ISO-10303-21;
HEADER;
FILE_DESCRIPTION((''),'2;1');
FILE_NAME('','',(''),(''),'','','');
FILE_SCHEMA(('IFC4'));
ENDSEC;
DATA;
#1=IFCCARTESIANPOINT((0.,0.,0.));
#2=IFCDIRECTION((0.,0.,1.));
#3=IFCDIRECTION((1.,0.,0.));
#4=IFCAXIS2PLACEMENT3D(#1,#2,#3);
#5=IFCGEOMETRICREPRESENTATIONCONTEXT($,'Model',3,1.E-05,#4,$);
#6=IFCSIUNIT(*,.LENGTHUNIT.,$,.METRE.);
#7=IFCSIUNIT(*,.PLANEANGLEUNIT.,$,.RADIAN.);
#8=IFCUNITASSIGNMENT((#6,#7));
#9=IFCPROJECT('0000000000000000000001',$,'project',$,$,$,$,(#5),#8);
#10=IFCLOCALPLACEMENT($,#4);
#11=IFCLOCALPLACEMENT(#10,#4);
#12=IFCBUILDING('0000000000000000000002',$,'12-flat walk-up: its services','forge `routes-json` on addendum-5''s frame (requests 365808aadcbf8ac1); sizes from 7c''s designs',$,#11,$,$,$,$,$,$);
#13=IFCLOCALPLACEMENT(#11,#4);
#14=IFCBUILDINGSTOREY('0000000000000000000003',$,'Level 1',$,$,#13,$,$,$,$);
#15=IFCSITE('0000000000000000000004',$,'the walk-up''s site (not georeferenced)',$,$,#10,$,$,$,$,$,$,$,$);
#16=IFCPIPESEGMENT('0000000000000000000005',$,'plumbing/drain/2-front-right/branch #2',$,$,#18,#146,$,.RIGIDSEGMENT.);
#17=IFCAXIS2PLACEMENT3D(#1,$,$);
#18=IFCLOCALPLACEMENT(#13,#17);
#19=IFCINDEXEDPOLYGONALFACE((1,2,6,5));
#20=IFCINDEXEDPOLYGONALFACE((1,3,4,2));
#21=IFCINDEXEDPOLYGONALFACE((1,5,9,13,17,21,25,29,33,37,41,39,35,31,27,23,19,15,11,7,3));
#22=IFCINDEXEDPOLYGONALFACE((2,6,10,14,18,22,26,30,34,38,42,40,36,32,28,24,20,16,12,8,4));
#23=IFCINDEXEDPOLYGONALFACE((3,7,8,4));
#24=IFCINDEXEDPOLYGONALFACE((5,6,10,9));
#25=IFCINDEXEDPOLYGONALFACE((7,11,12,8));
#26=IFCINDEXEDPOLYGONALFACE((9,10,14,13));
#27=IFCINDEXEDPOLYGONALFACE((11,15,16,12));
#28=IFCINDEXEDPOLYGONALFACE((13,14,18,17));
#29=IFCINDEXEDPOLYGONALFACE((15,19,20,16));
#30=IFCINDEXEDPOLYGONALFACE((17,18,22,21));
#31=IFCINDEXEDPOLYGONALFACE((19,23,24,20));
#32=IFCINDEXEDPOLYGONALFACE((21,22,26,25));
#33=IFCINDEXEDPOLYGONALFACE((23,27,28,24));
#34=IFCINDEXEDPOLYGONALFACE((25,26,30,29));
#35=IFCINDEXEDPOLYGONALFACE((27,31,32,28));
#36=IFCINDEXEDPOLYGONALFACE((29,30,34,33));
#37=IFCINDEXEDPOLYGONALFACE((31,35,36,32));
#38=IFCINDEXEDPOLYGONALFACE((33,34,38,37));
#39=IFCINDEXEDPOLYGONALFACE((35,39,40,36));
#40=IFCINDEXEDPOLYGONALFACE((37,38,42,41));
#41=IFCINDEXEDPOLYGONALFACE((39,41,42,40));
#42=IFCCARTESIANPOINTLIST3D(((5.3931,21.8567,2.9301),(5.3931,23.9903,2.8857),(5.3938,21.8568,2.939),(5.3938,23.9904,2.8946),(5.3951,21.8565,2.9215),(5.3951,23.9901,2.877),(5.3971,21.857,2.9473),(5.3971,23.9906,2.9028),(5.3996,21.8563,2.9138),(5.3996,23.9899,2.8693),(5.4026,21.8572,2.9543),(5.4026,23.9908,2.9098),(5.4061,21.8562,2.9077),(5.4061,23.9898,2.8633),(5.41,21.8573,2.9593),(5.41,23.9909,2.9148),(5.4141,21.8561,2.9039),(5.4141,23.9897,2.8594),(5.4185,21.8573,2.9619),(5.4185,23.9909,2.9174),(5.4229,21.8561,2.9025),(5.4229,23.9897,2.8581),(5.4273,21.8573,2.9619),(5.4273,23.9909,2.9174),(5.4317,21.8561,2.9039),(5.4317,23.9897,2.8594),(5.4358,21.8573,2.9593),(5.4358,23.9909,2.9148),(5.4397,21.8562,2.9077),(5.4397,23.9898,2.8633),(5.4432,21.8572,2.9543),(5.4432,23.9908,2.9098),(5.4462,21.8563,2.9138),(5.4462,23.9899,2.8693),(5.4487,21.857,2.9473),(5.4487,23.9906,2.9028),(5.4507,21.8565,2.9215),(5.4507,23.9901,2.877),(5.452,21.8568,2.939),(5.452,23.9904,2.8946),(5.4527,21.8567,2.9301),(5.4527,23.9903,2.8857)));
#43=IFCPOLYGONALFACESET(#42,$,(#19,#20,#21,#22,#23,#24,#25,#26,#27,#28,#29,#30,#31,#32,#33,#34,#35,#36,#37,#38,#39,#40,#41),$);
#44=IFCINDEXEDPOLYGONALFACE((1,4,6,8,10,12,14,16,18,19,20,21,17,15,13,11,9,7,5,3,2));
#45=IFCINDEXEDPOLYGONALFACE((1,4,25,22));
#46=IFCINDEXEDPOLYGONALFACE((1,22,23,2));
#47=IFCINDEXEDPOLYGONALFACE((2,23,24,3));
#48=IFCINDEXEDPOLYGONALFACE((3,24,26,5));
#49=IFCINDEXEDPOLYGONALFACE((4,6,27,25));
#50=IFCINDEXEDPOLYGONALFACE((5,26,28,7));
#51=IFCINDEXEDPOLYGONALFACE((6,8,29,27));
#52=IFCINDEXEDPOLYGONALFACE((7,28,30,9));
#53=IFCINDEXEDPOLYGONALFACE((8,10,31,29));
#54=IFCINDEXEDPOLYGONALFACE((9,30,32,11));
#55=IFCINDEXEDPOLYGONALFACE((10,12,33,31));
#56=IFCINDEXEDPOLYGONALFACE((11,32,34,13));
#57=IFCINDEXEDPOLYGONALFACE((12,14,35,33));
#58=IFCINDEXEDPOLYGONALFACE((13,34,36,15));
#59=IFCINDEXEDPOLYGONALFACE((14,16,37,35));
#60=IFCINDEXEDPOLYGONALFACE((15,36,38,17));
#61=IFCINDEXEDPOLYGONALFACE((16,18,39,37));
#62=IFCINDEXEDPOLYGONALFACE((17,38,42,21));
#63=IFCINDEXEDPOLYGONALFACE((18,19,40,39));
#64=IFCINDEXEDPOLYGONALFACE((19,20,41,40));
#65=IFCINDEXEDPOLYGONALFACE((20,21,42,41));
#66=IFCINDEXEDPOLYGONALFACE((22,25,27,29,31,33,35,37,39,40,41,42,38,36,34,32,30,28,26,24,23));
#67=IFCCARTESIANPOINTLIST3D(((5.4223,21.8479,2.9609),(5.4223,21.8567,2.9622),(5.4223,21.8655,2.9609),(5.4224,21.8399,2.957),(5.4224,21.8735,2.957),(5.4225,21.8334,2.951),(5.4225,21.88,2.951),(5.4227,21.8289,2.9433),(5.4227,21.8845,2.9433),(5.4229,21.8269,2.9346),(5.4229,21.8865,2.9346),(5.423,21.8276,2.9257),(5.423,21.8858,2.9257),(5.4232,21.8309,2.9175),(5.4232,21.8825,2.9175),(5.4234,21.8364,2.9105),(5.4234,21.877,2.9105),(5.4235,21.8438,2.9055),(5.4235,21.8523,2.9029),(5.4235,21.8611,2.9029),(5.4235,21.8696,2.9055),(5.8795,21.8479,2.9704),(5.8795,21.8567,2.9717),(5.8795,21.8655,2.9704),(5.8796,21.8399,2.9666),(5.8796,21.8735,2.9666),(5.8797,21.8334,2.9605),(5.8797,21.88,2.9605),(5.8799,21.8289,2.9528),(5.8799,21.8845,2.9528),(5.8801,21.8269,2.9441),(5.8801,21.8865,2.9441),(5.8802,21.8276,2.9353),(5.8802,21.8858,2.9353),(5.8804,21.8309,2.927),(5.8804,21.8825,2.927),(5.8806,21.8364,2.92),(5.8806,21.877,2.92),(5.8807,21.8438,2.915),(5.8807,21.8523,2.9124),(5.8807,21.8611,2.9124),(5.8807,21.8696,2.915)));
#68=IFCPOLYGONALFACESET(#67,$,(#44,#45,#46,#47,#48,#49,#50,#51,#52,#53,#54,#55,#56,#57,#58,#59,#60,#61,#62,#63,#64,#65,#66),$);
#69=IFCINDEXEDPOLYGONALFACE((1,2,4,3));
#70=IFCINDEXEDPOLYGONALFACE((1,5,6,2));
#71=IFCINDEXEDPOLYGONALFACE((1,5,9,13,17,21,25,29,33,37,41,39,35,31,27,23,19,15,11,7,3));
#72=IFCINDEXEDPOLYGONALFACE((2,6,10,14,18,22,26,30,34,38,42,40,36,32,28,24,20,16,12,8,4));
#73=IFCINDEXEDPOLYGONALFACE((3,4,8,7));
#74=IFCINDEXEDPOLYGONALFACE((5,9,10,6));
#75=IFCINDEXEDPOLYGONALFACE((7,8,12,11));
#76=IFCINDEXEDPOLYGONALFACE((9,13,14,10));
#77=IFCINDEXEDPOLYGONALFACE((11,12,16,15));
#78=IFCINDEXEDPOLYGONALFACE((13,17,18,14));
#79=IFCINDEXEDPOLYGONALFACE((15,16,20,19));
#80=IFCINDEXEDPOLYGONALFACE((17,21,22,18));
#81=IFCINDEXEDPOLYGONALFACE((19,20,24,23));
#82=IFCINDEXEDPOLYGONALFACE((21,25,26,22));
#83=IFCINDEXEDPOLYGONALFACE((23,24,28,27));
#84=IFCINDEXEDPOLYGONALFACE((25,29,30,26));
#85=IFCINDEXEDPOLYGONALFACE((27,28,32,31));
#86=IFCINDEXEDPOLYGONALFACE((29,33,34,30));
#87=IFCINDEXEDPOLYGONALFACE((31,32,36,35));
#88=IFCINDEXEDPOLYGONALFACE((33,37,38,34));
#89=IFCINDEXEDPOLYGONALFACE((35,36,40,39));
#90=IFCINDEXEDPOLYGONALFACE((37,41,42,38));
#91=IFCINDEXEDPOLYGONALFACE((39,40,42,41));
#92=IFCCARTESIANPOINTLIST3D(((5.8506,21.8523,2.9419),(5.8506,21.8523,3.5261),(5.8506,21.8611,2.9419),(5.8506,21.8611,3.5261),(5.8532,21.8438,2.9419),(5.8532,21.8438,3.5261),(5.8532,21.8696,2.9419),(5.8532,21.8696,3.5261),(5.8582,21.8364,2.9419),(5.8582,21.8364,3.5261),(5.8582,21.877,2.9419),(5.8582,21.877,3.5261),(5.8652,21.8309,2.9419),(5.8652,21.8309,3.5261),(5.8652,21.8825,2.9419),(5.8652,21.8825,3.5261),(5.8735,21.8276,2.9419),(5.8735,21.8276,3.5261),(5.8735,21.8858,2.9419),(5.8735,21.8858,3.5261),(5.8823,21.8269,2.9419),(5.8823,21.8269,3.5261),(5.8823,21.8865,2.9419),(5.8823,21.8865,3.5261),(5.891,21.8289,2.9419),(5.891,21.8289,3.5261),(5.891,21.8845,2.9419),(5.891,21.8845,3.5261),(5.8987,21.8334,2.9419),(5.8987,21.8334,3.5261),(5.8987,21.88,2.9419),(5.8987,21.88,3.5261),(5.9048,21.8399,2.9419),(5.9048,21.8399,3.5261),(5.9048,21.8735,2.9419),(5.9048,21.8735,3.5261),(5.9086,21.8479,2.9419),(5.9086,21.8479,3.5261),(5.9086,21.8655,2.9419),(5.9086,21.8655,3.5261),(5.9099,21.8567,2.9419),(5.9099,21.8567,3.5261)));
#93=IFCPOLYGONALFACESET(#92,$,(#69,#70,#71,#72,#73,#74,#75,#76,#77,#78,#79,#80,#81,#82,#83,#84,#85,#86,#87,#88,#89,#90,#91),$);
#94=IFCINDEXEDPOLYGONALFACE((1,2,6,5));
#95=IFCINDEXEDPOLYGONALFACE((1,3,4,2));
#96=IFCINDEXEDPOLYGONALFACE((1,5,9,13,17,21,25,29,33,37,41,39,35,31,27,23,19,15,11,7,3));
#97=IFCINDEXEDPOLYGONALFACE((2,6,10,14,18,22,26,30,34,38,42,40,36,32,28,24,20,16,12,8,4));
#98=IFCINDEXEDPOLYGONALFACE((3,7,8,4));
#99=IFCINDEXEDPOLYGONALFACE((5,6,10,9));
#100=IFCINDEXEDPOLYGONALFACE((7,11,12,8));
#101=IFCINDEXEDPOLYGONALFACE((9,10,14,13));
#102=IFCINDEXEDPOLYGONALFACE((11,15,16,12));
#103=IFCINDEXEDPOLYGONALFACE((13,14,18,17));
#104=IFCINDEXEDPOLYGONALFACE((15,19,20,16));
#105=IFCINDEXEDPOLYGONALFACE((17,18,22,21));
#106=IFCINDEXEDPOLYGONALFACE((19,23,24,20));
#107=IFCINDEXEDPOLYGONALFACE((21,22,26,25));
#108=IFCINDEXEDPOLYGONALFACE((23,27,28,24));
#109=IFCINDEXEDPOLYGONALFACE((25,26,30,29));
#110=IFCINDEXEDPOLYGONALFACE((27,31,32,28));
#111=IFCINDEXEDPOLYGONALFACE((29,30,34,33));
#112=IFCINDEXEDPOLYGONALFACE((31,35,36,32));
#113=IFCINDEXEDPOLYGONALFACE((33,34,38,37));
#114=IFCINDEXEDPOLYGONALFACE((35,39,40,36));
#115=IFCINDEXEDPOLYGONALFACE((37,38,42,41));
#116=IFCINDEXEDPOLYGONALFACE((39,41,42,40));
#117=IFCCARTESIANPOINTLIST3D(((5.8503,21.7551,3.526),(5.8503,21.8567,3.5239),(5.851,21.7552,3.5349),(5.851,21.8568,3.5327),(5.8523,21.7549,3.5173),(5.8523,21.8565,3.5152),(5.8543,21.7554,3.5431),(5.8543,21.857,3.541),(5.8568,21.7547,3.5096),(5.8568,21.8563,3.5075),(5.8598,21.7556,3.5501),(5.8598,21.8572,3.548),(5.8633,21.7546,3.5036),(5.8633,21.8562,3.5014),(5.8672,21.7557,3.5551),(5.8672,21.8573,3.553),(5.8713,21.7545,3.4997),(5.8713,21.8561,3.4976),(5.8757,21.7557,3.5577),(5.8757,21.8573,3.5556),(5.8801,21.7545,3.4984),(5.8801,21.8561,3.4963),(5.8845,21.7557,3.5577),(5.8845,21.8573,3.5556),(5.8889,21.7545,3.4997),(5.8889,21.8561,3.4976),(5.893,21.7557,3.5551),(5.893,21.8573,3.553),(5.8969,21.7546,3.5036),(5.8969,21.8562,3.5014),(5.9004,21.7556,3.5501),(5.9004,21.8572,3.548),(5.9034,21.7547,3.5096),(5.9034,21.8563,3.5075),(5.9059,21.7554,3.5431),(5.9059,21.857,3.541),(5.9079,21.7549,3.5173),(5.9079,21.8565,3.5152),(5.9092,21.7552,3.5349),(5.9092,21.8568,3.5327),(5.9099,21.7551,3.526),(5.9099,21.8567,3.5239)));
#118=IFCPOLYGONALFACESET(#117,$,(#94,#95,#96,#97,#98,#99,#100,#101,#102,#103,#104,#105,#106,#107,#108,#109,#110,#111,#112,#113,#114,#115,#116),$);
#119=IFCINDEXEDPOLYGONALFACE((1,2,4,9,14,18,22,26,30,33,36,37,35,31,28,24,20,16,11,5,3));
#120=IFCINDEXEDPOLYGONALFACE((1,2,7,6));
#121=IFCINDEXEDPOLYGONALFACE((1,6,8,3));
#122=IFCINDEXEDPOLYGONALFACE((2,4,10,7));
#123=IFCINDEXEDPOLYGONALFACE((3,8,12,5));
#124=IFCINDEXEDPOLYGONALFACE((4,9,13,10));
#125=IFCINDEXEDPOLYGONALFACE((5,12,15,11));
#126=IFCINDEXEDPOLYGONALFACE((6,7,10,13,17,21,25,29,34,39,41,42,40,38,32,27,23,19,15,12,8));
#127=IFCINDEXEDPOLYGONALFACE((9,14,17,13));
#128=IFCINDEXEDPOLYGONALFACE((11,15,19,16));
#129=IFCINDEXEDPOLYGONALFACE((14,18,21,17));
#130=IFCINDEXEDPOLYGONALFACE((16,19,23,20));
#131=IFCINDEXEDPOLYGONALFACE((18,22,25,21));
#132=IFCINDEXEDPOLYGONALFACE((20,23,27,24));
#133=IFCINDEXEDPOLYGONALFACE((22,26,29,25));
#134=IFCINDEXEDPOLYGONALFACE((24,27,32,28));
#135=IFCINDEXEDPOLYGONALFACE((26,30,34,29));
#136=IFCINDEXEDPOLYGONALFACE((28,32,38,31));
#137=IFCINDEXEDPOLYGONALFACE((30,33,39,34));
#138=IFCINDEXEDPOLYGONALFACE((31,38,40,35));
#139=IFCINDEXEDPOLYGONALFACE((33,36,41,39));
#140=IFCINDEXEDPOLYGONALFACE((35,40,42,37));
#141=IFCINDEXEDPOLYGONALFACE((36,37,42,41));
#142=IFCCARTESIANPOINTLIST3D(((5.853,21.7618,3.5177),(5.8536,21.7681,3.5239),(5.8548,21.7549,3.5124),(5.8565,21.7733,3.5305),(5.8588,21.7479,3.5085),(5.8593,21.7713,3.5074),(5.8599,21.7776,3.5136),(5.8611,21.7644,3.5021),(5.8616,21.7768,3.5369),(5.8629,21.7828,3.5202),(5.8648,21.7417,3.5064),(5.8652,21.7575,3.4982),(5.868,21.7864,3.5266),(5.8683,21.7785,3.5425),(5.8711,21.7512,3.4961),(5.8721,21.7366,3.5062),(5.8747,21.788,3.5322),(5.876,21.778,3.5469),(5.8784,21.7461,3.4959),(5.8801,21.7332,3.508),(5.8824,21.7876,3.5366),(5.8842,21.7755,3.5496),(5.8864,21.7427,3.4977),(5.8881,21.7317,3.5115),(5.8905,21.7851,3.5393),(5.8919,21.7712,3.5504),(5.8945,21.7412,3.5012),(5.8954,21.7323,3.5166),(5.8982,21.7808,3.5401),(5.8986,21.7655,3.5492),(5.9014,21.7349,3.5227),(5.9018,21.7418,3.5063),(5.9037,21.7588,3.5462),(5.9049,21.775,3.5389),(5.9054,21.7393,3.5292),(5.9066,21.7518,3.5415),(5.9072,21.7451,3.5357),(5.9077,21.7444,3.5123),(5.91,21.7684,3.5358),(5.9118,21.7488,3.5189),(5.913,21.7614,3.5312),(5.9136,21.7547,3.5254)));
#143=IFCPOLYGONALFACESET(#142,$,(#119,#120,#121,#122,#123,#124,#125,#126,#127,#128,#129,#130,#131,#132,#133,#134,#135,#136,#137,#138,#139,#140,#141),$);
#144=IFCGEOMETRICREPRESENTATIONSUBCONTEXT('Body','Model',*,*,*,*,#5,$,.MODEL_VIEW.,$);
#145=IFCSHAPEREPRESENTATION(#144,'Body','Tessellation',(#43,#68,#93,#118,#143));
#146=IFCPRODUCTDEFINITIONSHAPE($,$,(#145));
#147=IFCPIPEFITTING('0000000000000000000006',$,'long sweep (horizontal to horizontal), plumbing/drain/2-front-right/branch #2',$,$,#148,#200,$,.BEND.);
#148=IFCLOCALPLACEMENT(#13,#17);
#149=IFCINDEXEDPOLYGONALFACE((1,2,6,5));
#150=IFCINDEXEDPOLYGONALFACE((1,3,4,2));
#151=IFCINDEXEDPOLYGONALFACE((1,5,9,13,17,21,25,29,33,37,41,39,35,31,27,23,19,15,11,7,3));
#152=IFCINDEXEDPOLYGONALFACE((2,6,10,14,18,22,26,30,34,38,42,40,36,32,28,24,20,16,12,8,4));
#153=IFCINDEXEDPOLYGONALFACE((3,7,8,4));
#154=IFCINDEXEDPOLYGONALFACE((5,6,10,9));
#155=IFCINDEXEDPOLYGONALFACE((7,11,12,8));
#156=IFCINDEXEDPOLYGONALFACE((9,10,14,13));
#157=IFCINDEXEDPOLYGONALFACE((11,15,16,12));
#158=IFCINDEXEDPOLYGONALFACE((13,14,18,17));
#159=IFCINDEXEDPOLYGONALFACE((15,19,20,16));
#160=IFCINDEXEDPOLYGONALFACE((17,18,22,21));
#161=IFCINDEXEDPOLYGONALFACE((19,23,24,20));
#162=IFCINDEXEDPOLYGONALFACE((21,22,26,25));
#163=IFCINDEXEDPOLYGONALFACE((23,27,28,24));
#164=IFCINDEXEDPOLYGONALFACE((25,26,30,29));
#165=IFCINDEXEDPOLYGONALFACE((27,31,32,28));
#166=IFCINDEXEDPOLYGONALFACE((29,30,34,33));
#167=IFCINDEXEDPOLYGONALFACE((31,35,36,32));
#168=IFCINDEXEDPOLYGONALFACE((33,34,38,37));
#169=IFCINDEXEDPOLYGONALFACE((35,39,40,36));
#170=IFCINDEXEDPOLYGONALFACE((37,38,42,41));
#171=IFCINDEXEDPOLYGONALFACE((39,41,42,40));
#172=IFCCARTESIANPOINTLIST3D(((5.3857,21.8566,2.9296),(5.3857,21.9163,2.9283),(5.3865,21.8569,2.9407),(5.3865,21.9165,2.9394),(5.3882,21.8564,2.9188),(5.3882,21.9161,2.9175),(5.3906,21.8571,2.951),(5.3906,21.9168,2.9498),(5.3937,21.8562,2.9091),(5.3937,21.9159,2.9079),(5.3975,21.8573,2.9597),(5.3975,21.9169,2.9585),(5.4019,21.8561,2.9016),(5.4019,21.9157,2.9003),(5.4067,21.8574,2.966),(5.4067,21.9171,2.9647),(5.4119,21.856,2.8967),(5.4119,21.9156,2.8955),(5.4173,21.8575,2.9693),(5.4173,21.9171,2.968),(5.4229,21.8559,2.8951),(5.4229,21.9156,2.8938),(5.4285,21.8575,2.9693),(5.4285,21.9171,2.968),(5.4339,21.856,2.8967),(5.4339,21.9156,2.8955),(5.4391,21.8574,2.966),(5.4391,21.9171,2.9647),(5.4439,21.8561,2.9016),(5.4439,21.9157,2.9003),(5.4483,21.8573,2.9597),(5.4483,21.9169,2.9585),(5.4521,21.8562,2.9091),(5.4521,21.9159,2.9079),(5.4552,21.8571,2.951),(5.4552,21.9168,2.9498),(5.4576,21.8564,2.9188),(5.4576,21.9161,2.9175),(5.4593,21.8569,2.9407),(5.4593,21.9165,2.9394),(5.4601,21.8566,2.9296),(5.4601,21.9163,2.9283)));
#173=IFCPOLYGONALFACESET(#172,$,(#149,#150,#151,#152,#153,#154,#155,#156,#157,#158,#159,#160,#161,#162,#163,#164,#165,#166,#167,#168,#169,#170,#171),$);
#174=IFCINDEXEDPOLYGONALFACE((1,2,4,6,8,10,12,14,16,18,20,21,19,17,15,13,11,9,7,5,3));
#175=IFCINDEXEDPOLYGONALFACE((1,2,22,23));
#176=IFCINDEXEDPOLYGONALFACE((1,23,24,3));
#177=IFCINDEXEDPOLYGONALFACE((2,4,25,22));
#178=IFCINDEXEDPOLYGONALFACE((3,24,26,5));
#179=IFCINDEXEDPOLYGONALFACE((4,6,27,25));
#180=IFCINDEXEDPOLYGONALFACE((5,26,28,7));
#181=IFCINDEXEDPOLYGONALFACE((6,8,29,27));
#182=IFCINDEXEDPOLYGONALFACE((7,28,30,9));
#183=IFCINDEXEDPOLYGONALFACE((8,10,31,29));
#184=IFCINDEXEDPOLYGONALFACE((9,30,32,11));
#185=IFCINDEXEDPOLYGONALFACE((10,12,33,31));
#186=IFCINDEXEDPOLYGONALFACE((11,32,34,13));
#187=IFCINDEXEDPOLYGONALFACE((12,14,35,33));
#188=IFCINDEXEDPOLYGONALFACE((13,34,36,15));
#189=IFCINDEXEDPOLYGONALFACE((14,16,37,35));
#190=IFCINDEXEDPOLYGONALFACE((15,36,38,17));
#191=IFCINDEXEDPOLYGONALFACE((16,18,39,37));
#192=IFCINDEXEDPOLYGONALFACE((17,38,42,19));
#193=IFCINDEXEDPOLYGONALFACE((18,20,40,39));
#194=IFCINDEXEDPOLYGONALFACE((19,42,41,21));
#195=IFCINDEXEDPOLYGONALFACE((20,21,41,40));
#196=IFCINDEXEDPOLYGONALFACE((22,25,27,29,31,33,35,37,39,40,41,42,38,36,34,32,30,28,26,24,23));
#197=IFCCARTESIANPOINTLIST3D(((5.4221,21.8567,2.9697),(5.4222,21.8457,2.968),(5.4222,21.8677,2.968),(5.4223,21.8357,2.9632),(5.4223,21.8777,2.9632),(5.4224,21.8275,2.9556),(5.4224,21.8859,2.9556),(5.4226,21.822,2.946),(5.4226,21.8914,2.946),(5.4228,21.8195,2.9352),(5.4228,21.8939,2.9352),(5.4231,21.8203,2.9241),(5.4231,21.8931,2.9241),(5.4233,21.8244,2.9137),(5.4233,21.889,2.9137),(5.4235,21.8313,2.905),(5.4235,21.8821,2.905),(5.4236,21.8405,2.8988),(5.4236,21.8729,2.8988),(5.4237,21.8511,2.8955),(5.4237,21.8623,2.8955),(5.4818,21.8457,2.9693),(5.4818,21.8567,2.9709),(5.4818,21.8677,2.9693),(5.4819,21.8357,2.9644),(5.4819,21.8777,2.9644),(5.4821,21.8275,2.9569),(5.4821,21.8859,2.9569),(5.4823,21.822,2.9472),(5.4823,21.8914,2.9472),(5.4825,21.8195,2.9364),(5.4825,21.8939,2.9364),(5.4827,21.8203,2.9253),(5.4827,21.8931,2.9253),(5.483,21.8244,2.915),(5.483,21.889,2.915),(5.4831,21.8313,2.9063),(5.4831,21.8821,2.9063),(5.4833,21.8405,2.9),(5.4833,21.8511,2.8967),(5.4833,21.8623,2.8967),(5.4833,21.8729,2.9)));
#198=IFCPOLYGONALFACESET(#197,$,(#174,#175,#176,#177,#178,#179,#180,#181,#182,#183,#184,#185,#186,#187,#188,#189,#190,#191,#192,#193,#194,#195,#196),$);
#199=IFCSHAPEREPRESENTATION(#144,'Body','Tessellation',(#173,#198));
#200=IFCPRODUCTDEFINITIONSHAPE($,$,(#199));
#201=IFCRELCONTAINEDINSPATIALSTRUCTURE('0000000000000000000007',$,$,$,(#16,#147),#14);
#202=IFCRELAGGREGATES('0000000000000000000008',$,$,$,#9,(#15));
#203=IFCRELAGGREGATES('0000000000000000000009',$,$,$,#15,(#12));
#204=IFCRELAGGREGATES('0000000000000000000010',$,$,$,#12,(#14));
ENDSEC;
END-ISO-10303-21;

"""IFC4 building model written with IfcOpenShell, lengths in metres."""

from ifc_helpers import new_model, entity, si_unit, frame, origin_with_axes, place, context, subcontext, project, spatial, element, save


model = new_model("IFC4")

# Units and contexts
model_context = context("Model", 3, precision=1e-05, world=origin_with_axes())
body_context = subcontext(model_context, "Body", "Model", "MODEL_VIEW")
ifc_project = project(units=[si_unit("LENGTHUNIT", "METRE"), si_unit("PLANEANGLEUNIT", "RADIAN")], contexts=[model_context])

# Site, building, storey
site_placement = place(None, origin_with_axes())
site = spatial("IfcSite", under=ifc_project, at=site_placement, Name="the walk-up's site (not georeferenced)")
building_placement = place(site_placement, origin_with_axes())
building = spatial("IfcBuilding", under=site, at=building_placement, Name="12-flat walk-up: its services", Description="forge `routes-json` on addendum-5's frame (requests 365808aadcbf8ac1); sizes from 7c's designs")
storey_placement = place(building_placement, origin_with_axes())
storey = spatial("IfcBuildingStorey", under=building, at=storey_placement, Name="Level 1")

# Pipe segment
pipe_segment_1_placement = place(storey_placement, frame((5.4229, 23.9903, 2.8879), z_axis=(0.0, 0.0, 1.0), x_axis=(1.0, 0.0, 0.0)))
element("IfcPipeSegment", 1, at=pipe_segment_1_placement, inside=storey, Name="plumbing/drain/2-front-right/branch #2", PredefinedType="RIGIDSEGMENT", context=body_context, shape_type="AdvancedSweptSolid", body=[
    entity("IfcSweptDiskSolid", entity("IfcPolyline", [entity("IfcCartesianPoint", [0.0, 0.0, 0.0]), entity("IfcCartesianPoint", [0.0, -2.1336, 0.0444])]), 0.0298),
    entity("IfcSweptDiskSolid", entity("IfcPolyline", [entity("IfcCartesianPoint", [0.0, -2.1336, 0.0444]), entity("IfcCartesianPoint", [0.4572, -2.1336, 0.054])]), 0.0298),
    entity("IfcSweptDiskSolid", entity("IfcPolyline", [entity("IfcCartesianPoint", [0.4572, -2.1336, 0.054]), entity("IfcCartesianPoint", [0.4572, -2.1336, 0.6382])]), 0.0298),
    entity("IfcSweptDiskSolid", entity("IfcPolyline", [entity("IfcCartesianPoint", [0.4572, -2.1336, 0.6382]), entity("IfcCartesianPoint", [0.4572, -2.2352, 0.6403])]), 0.0298),
    entity("IfcSweptDiskSolid", entity("IfcPolyline", [entity("IfcCartesianPoint", [0.4572, -2.2352, 0.6403]), entity("IfcCartesianPoint", [0.4635, -2.2257, 0.63])]), 0.0298),
])

# Pipe fitting
pipe_fitting_1_placement = place(storey_placement, frame((5.4229, 21.9164, 2.9311), z_axis=(0.0, 0.0, 1.0), x_axis=(1.0, 0.0, 0.0)))
element("IfcPipeFitting", 2, at=pipe_fitting_1_placement, inside=storey, Name="long sweep (horizontal to horizontal), plumbing/drain/2-front-right/branch #2", PredefinedType="BEND", context=body_context, shape_type="AdvancedSweptSolid", body=[
    entity("IfcSweptDiskSolid", entity("IfcPolyline", [entity("IfcCartesianPoint", [0.0, 0.0, 0.0]), entity("IfcCartesianPoint", [0.0, -0.0597, 0.0012])]), 0.0373),
    entity("IfcSweptDiskSolid", entity("IfcPolyline", [entity("IfcCartesianPoint", [0.0, -0.0597, 0.0012]), entity("IfcCartesianPoint", [0.0597, -0.0597, 0.0025])]), 0.0373),
])

save(model, "model.ifc")
